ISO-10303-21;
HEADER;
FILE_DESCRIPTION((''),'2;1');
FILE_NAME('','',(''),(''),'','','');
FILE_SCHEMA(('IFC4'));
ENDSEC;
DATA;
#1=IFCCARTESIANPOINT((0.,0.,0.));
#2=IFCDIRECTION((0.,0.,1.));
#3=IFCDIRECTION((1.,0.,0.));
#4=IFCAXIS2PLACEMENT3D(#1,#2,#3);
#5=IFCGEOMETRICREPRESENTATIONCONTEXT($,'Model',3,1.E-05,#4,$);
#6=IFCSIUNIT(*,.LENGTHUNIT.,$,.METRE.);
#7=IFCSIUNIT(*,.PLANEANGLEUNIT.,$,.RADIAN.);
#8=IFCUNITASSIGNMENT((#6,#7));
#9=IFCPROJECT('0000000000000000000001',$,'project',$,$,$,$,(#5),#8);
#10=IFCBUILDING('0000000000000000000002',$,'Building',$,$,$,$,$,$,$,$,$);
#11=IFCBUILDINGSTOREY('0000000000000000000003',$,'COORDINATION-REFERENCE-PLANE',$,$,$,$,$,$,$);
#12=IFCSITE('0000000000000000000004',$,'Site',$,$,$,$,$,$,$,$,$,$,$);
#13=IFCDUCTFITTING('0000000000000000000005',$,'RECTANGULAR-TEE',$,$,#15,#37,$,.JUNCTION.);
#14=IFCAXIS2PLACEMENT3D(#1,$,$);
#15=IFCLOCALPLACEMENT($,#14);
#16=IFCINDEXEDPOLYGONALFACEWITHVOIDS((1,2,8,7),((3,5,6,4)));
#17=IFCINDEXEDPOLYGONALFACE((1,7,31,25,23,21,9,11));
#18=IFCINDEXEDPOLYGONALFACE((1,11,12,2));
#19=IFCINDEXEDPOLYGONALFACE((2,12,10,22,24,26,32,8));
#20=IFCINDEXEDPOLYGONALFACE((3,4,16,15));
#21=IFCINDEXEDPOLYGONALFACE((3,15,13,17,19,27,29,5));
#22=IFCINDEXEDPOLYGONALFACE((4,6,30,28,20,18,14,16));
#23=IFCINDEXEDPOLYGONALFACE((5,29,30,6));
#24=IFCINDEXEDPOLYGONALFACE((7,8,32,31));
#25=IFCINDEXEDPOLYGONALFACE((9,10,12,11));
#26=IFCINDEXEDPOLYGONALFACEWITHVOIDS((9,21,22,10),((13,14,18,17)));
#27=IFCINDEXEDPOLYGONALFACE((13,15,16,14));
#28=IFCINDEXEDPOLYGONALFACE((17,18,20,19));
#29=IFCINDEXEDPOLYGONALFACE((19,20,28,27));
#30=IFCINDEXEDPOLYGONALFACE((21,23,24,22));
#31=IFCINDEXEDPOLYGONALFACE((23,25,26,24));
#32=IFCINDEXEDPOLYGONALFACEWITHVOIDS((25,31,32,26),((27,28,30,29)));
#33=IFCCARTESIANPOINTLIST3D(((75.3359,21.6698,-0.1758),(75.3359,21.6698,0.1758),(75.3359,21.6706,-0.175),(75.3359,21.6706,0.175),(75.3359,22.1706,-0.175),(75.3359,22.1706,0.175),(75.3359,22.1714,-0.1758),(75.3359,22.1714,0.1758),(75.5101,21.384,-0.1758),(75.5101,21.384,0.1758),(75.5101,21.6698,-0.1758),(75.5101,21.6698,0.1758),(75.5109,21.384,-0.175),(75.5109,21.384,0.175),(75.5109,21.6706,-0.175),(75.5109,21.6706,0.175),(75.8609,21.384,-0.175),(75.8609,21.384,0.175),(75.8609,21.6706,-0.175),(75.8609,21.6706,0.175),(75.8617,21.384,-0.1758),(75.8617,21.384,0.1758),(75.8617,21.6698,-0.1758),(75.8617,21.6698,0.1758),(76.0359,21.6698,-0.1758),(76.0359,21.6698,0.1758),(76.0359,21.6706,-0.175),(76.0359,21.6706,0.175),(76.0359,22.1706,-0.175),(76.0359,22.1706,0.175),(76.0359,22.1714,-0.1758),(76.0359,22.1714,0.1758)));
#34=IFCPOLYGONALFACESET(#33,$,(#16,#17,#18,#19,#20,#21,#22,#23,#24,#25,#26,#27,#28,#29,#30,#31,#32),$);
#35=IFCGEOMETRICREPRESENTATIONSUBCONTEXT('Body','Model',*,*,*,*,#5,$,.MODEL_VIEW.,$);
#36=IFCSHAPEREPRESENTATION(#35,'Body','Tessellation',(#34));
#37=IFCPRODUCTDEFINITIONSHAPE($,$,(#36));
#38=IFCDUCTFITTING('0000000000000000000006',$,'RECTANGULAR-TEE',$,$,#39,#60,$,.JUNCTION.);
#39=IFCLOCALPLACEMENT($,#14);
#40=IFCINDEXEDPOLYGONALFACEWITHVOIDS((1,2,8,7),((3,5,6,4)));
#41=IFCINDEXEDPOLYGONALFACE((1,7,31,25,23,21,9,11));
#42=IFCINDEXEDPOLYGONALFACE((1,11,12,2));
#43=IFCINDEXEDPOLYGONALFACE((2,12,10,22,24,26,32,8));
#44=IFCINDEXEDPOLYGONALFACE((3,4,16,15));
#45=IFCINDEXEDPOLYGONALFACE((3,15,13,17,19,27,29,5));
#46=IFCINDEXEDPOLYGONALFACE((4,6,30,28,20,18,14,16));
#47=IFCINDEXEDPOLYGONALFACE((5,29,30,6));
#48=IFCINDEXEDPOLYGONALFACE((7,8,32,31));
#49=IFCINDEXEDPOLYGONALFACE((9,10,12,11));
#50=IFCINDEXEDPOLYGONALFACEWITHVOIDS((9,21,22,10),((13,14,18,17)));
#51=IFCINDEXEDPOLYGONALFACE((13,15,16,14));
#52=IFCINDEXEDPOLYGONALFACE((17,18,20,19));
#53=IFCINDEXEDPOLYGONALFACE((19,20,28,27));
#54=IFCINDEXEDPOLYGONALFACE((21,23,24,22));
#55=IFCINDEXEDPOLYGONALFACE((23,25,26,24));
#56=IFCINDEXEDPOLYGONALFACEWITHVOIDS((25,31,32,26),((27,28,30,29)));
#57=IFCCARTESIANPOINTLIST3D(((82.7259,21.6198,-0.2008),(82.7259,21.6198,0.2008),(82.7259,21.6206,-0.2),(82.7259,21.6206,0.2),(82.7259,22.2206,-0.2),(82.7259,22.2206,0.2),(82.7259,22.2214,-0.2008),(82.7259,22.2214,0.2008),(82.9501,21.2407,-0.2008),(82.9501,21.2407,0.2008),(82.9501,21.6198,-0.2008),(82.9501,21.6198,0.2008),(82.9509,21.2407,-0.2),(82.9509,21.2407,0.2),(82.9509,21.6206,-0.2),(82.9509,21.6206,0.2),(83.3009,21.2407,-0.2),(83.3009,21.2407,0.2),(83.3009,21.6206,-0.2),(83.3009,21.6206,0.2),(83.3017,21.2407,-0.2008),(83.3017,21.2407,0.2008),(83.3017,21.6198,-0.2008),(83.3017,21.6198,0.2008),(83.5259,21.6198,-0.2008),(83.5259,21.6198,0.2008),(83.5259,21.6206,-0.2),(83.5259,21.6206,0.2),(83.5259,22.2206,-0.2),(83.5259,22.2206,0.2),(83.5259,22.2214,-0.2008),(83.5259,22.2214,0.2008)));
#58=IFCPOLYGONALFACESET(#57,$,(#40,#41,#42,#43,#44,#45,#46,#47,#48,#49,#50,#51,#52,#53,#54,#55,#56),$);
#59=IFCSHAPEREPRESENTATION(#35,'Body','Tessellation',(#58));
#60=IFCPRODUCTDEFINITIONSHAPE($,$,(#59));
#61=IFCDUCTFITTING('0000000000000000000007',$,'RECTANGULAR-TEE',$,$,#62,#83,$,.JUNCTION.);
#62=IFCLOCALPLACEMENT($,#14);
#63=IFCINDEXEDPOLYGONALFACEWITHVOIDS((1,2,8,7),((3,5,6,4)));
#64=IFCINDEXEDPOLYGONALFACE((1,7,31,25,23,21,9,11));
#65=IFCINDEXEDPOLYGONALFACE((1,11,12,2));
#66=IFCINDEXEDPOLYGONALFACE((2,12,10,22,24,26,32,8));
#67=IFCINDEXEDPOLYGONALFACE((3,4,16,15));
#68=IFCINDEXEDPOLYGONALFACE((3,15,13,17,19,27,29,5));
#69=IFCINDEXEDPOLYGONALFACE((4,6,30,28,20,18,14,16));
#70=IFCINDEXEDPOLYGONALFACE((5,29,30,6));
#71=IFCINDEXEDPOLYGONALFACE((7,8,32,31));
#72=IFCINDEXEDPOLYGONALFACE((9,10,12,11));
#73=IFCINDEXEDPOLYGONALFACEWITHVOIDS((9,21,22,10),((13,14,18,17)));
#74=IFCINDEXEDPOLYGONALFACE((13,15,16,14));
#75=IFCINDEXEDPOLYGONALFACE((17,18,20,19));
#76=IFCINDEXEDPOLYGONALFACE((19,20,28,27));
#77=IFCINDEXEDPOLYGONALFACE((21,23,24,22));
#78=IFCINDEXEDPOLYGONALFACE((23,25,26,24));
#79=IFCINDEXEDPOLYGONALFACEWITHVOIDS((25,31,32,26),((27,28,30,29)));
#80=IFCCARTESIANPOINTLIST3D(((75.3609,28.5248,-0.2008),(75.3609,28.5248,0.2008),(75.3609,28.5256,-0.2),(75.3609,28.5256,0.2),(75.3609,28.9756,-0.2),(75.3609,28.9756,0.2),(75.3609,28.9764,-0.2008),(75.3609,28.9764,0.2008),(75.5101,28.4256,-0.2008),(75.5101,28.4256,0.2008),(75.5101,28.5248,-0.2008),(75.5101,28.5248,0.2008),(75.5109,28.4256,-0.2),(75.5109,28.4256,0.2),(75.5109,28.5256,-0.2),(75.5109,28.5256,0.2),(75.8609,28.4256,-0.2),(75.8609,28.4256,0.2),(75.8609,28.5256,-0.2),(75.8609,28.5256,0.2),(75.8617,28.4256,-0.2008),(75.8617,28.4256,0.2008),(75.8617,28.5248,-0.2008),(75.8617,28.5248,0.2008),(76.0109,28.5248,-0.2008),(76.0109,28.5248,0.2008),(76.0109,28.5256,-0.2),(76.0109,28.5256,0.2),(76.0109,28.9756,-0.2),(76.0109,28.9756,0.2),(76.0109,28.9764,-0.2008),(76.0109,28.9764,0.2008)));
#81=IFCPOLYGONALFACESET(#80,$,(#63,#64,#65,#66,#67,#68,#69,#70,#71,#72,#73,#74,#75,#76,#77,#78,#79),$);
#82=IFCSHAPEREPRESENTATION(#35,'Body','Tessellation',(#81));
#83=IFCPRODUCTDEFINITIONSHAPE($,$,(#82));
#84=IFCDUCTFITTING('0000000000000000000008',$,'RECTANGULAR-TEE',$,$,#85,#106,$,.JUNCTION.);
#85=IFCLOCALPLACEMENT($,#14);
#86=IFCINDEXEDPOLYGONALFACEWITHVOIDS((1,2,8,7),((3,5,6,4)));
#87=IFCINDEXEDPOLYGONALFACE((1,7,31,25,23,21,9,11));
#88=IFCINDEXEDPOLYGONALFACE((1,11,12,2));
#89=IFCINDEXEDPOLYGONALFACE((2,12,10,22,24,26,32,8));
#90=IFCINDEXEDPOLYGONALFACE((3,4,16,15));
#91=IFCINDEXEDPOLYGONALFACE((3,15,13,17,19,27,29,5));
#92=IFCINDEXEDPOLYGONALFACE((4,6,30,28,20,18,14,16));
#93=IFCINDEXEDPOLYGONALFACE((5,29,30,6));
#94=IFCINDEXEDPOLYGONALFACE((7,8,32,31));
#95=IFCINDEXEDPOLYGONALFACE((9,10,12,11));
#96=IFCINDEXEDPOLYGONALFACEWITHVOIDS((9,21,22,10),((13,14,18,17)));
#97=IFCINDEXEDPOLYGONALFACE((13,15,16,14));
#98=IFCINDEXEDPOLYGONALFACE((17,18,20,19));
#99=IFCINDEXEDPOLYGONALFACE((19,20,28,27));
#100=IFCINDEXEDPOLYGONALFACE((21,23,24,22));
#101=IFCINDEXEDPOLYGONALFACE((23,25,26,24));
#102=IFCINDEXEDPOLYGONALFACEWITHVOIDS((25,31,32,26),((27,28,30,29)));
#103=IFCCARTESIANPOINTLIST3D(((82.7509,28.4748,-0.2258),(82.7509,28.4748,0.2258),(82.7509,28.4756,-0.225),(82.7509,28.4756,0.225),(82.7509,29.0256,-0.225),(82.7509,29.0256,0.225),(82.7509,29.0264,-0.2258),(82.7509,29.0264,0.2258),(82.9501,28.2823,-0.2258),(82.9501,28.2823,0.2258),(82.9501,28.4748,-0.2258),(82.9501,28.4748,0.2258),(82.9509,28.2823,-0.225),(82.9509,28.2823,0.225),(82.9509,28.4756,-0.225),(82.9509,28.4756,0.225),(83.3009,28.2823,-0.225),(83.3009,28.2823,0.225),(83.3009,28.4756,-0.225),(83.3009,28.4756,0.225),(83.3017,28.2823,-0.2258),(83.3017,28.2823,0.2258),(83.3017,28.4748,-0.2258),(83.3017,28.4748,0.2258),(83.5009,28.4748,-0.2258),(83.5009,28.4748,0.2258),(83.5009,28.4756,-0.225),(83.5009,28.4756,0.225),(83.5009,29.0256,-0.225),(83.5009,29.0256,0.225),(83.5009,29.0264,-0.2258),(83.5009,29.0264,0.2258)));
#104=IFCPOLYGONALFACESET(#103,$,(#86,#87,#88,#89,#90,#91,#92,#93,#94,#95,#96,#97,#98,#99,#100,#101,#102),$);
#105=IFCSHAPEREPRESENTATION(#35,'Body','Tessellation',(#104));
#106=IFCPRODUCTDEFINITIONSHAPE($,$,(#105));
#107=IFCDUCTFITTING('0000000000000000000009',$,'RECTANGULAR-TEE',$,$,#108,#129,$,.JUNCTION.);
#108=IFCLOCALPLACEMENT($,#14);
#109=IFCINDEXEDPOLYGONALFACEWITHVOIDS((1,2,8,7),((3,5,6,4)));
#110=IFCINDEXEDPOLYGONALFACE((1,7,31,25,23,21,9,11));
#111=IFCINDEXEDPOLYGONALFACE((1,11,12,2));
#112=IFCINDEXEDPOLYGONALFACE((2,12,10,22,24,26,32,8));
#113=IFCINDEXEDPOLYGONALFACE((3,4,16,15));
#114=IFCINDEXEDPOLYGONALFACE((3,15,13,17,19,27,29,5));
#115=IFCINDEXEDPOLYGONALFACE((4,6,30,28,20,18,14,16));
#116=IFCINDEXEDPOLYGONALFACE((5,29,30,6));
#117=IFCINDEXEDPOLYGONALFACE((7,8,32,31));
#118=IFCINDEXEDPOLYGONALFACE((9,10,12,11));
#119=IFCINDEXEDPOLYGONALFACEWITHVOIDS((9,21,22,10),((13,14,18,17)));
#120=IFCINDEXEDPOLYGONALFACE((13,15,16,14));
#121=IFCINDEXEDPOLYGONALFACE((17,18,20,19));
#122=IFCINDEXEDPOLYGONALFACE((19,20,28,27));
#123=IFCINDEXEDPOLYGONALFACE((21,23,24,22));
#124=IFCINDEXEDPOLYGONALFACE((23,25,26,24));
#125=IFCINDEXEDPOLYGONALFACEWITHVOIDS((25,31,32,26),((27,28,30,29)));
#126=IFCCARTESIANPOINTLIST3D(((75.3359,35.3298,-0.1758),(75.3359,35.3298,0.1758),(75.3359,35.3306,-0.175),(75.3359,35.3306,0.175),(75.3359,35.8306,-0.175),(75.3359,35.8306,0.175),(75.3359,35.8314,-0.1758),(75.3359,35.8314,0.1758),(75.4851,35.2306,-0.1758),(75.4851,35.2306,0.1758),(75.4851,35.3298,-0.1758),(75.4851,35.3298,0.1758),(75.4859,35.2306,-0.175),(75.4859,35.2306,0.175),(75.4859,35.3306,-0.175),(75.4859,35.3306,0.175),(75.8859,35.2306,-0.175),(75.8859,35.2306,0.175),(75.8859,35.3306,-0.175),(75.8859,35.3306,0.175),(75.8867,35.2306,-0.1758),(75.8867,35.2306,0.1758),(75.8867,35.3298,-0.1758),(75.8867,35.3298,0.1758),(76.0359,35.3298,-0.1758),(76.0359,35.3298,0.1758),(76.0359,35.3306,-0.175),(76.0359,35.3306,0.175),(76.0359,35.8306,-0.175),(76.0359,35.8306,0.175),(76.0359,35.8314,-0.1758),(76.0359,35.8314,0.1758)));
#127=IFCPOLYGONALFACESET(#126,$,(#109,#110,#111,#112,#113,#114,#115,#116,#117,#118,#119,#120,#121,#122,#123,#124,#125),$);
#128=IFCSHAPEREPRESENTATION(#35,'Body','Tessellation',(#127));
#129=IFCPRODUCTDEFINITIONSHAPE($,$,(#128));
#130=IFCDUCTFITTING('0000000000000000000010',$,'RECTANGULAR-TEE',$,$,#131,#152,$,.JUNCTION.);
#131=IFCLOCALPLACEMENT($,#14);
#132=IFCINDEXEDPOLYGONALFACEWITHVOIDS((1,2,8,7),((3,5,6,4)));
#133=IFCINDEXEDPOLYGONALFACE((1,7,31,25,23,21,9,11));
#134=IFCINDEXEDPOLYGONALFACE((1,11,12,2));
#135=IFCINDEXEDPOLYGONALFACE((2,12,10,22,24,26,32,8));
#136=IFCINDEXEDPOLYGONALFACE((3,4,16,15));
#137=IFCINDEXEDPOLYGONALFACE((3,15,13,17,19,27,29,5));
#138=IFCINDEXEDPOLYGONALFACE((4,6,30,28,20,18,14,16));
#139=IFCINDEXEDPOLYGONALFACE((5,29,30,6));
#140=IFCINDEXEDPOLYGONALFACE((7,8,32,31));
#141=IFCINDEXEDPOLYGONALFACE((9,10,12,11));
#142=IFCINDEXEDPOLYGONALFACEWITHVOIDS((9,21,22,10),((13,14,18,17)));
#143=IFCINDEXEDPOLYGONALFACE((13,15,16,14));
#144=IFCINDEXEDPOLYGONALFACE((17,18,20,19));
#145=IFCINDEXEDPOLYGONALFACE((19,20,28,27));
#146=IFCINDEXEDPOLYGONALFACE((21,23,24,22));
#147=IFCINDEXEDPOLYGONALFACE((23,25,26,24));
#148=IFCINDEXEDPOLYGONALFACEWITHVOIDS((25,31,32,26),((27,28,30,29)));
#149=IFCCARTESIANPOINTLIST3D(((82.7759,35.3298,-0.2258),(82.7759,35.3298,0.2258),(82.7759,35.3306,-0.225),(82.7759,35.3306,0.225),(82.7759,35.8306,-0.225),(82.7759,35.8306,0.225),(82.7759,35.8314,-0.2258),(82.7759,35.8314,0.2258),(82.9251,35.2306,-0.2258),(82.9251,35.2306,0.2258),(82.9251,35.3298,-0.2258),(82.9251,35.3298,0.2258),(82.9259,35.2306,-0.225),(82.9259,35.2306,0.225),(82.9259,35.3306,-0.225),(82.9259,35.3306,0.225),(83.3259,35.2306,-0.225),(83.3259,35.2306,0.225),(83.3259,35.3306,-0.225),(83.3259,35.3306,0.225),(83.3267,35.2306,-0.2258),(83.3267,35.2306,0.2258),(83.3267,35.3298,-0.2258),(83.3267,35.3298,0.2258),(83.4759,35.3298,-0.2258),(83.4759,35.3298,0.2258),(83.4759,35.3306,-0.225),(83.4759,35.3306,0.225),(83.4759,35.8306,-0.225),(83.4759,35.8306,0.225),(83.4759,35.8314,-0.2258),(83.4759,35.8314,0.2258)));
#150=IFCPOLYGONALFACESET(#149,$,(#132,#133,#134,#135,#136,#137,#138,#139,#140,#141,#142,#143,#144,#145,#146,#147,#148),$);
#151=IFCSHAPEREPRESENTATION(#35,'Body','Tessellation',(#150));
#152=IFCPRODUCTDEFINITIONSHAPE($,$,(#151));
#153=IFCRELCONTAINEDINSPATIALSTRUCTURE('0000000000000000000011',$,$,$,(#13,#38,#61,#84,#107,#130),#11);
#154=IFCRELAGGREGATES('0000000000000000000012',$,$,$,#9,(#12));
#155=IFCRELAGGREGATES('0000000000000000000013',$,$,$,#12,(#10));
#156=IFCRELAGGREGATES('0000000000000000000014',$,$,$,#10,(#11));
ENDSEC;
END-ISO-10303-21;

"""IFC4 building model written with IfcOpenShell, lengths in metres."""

from ifc_helpers import new_model, si_unit, frame, origin_with_axes, place, context, subcontext, project, spatial, rectangle, extrude, boolean, element, save


model = new_model("IFC4")

# Units and contexts
model_context = context("Model", 3, precision=1e-05, world=origin_with_axes())
body_context = subcontext(model_context, "Body", "Model", "MODEL_VIEW")
ifc_project = project(units=[si_unit("LENGTHUNIT", "METRE"), si_unit("PLANEANGLEUNIT", "RADIAN")], contexts=[model_context])

# Site, building, storey
site = spatial("IfcSite", under=ifc_project, Name="Site")
building = spatial("IfcBuilding", under=site, Name="Building")
storey = spatial("IfcBuildingStorey", under=building, Name="COORDINATION-REFERENCE-PLANE")

# Duct fittings
duct_fitting_1_placement = place(None, frame((75.6859, 21.9206, 0.0), z_axis=(-1.0, 0.0, 0.0), x_axis=(0.0, -1.0, 0.0)))
solid_1 = boolean("UNION", extrude(rectangle(XDim=0.5, YDim=0.35), frame((0.0, 0.0, -0.35), z_axis=(0.0, 0.0, 1.0), x_axis=(1.0, 0.0, 0.0)), (0.0, 0.0, 1.0), 0.7), extrude(rectangle(XDim=0.35, YDim=0.35), frame((0.0, 0.0, 0.0), z_axis=(1.0, 0.0, 0.0), x_axis=(0.0, 0.0, -1.0)), (0.0, 0.0, 1.0), 0.5366))
element("IfcDuctFitting", 1, at=duct_fitting_1_placement, inside=storey, Name="RECTANGULAR-TEE", PredefinedType="JUNCTION", context=body_context, shape_type="CSG", body=[
    boolean("DIFFERENCE", boolean("UNION", extrude(rectangle(XDim=0.5016, YDim=0.3516), frame((0.0, 0.0, -0.35), z_axis=(0.0, 0.0, 1.0), x_axis=(1.0, 0.0, 0.0)), (0.0, 0.0, 1.0), 0.7), extrude(rectangle(XDim=0.3516, YDim=0.3516), frame((0.0, 0.0, 0.0), z_axis=(1.0, 0.0, 0.0), x_axis=(0.0, 0.0, -1.0)), (0.0, 0.0, 1.0), 0.5366)), solid_1),
])
duct_fitting_2_placement = place(None, frame((83.1259, 21.9206, 0.0), z_axis=(-1.0, 0.0, 0.0), x_axis=(0.0, -1.0, 0.0)))
solid_2 = boolean("UNION", extrude(rectangle(XDim=0.6, YDim=0.4), frame((0.0, 0.0, -0.4), z_axis=(0.0, 0.0, 1.0), x_axis=(1.0, 0.0, 0.0)), (0.0, 0.0, 1.0), 0.8), extrude(rectangle(XDim=0.35, YDim=0.4), frame((0.0, 0.0, 0.0), z_axis=(1.0, 0.0, 0.0), x_axis=(0.0, 0.0, -1.0)), (0.0, 0.0, 1.0), 0.6799))
element("IfcDuctFitting", 2, at=duct_fitting_2_placement, inside=storey, Name="RECTANGULAR-TEE", PredefinedType="JUNCTION", context=body_context, shape_type="CSG", body=[
    boolean("DIFFERENCE", boolean("UNION", extrude(rectangle(XDim=0.6016, YDim=0.4016), frame((0.0, 0.0, -0.4), z_axis=(0.0, 0.0, 1.0), x_axis=(1.0, 0.0, 0.0)), (0.0, 0.0, 1.0), 0.8), extrude(rectangle(XDim=0.3516, YDim=0.4016), frame((0.0, 0.0, 0.0), z_axis=(1.0, 0.0, 0.0), x_axis=(0.0, 0.0, -1.0)), (0.0, 0.0, 1.0), 0.6799)), solid_2),
])
duct_fitting_3_placement = place(None, frame((75.6859, 28.7506, 0.0), z_axis=(-1.0, 0.0, 0.0), x_axis=(0.0, -1.0, 0.0)))
solid_3 = boolean("UNION", extrude(rectangle(XDim=0.45, YDim=0.4), frame((0.0, 0.0, -0.325), z_axis=(0.0, 0.0, 1.0), x_axis=(1.0, 0.0, 0.0)), (0.0, 0.0, 1.0), 0.65), extrude(rectangle(XDim=0.35, YDim=0.4), frame((0.0, 0.0, 0.0), z_axis=(1.0, 0.0, 0.0), x_axis=(0.0, 0.0, -1.0)), (0.0, 0.0, 1.0), 0.325))
element("IfcDuctFitting", 3, at=duct_fitting_3_placement, inside=storey, Name="RECTANGULAR-TEE", PredefinedType="JUNCTION", context=body_context, shape_type="CSG", body=[
    boolean("DIFFERENCE", boolean("UNION", extrude(rectangle(XDim=0.4516, YDim=0.4016), frame((0.0, 0.0, -0.325), z_axis=(0.0, 0.0, 1.0), x_axis=(1.0, 0.0, 0.0)), (0.0, 0.0, 1.0), 0.65), extrude(rectangle(XDim=0.3516, YDim=0.4016), frame((0.0, 0.0, 0.0), z_axis=(1.0, 0.0, 0.0), x_axis=(0.0, 0.0, -1.0)), (0.0, 0.0, 1.0), 0.325)), solid_3),
])
duct_fitting_4_placement = place(None, frame((83.1259, 28.7506, 0.0), z_axis=(-1.0, 0.0, 0.0), x_axis=(0.0, -1.0, 0.0)))
solid_4 = boolean("UNION", extrude(rectangle(XDim=0.55, YDim=0.45), frame((0.0, 0.0, -0.375), z_axis=(0.0, 0.0, 1.0), x_axis=(1.0, 0.0, 0.0)), (0.0, 0.0, 1.0), 0.75), extrude(rectangle(XDim=0.35, YDim=0.45), frame((0.0, 0.0, 0.0), z_axis=(1.0, 0.0, 0.0), x_axis=(0.0, 0.0, -1.0)), (0.0, 0.0, 1.0), 0.4683))
element("IfcDuctFitting", 4, at=duct_fitting_4_placement, inside=storey, Name="RECTANGULAR-TEE", PredefinedType="JUNCTION", context=body_context, shape_type="CSG", body=[
    boolean("DIFFERENCE", boolean("UNION", extrude(rectangle(XDim=0.5516, YDim=0.4516), frame((0.0, 0.0, -0.375), z_axis=(0.0, 0.0, 1.0), x_axis=(1.0, 0.0, 0.0)), (0.0, 0.0, 1.0), 0.75), extrude(rectangle(XDim=0.3516, YDim=0.4516), frame((0.0, 0.0, 0.0), z_axis=(1.0, 0.0, 0.0), x_axis=(0.0, 0.0, -1.0)), (0.0, 0.0, 1.0), 0.4683)), solid_4),
])
duct_fitting_5_placement = place(None, frame((75.6859, 35.5806, 0.0), z_axis=(-1.0, 0.0, 0.0), x_axis=(0.0, -1.0, 0.0)))
solid_5 = boolean("UNION", extrude(rectangle(XDim=0.5, YDim=0.35), frame((0.0, 0.0, -0.35), z_axis=(0.0, 0.0, 1.0), x_axis=(1.0, 0.0, 0.0)), (0.0, 0.0, 1.0), 0.7), extrude(rectangle(XDim=0.4, YDim=0.35), frame((0.0, 0.0, 0.0), z_axis=(1.0, 0.0, 0.0), x_axis=(0.0, 0.0, -1.0)), (0.0, 0.0, 1.0), 0.35))
element("IfcDuctFitting", 5, at=duct_fitting_5_placement, inside=storey, Name="RECTANGULAR-TEE", PredefinedType="JUNCTION", context=body_context, shape_type="CSG", body=[
    boolean("DIFFERENCE", boolean("UNION", extrude(rectangle(XDim=0.5016, YDim=0.3516), frame((0.0, 0.0, -0.35), z_axis=(0.0, 0.0, 1.0), x_axis=(1.0, 0.0, 0.0)), (0.0, 0.0, 1.0), 0.7), extrude(rectangle(XDim=0.4016, YDim=0.3516), frame((0.0, 0.0, 0.0), z_axis=(1.0, 0.0, 0.0), x_axis=(0.0, 0.0, -1.0)), (0.0, 0.0, 1.0), 0.35)), solid_5),
])
duct_fitting_6_placement = place(None, frame((83.1259, 35.5806, 0.0), z_axis=(-1.0, 0.0, 0.0), x_axis=(0.0, -1.0, 0.0)))
solid_6 = boolean("UNION", extrude(rectangle(XDim=0.5, YDim=0.45), frame((0.0, 0.0, -0.35), z_axis=(0.0, 0.0, 1.0), x_axis=(1.0, 0.0, 0.0)), (0.0, 0.0, 1.0), 0.7), extrude(rectangle(XDim=0.4, YDim=0.45), frame((0.0, 0.0, 0.0), z_axis=(1.0, 0.0, 0.0), x_axis=(0.0, 0.0, -1.0)), (0.0, 0.0, 1.0), 0.35))
element("IfcDuctFitting", 6, at=duct_fitting_6_placement, inside=storey, Name="RECTANGULAR-TEE", PredefinedType="JUNCTION", context=body_context, shape_type="CSG", body=[
    boolean("DIFFERENCE", boolean("UNION", extrude(rectangle(XDim=0.5016, YDim=0.4516), frame((0.0, 0.0, -0.35), z_axis=(0.0, 0.0, 1.0), x_axis=(1.0, 0.0, 0.0)), (0.0, 0.0, 1.0), 0.7), extrude(rectangle(XDim=0.4016, YDim=0.4516), frame((0.0, 0.0, 0.0), z_axis=(1.0, 0.0, 0.0), x_axis=(0.0, 0.0, -1.0)), (0.0, 0.0, 1.0), 0.35)), solid_6),
])

save(model, "model.ifc")
